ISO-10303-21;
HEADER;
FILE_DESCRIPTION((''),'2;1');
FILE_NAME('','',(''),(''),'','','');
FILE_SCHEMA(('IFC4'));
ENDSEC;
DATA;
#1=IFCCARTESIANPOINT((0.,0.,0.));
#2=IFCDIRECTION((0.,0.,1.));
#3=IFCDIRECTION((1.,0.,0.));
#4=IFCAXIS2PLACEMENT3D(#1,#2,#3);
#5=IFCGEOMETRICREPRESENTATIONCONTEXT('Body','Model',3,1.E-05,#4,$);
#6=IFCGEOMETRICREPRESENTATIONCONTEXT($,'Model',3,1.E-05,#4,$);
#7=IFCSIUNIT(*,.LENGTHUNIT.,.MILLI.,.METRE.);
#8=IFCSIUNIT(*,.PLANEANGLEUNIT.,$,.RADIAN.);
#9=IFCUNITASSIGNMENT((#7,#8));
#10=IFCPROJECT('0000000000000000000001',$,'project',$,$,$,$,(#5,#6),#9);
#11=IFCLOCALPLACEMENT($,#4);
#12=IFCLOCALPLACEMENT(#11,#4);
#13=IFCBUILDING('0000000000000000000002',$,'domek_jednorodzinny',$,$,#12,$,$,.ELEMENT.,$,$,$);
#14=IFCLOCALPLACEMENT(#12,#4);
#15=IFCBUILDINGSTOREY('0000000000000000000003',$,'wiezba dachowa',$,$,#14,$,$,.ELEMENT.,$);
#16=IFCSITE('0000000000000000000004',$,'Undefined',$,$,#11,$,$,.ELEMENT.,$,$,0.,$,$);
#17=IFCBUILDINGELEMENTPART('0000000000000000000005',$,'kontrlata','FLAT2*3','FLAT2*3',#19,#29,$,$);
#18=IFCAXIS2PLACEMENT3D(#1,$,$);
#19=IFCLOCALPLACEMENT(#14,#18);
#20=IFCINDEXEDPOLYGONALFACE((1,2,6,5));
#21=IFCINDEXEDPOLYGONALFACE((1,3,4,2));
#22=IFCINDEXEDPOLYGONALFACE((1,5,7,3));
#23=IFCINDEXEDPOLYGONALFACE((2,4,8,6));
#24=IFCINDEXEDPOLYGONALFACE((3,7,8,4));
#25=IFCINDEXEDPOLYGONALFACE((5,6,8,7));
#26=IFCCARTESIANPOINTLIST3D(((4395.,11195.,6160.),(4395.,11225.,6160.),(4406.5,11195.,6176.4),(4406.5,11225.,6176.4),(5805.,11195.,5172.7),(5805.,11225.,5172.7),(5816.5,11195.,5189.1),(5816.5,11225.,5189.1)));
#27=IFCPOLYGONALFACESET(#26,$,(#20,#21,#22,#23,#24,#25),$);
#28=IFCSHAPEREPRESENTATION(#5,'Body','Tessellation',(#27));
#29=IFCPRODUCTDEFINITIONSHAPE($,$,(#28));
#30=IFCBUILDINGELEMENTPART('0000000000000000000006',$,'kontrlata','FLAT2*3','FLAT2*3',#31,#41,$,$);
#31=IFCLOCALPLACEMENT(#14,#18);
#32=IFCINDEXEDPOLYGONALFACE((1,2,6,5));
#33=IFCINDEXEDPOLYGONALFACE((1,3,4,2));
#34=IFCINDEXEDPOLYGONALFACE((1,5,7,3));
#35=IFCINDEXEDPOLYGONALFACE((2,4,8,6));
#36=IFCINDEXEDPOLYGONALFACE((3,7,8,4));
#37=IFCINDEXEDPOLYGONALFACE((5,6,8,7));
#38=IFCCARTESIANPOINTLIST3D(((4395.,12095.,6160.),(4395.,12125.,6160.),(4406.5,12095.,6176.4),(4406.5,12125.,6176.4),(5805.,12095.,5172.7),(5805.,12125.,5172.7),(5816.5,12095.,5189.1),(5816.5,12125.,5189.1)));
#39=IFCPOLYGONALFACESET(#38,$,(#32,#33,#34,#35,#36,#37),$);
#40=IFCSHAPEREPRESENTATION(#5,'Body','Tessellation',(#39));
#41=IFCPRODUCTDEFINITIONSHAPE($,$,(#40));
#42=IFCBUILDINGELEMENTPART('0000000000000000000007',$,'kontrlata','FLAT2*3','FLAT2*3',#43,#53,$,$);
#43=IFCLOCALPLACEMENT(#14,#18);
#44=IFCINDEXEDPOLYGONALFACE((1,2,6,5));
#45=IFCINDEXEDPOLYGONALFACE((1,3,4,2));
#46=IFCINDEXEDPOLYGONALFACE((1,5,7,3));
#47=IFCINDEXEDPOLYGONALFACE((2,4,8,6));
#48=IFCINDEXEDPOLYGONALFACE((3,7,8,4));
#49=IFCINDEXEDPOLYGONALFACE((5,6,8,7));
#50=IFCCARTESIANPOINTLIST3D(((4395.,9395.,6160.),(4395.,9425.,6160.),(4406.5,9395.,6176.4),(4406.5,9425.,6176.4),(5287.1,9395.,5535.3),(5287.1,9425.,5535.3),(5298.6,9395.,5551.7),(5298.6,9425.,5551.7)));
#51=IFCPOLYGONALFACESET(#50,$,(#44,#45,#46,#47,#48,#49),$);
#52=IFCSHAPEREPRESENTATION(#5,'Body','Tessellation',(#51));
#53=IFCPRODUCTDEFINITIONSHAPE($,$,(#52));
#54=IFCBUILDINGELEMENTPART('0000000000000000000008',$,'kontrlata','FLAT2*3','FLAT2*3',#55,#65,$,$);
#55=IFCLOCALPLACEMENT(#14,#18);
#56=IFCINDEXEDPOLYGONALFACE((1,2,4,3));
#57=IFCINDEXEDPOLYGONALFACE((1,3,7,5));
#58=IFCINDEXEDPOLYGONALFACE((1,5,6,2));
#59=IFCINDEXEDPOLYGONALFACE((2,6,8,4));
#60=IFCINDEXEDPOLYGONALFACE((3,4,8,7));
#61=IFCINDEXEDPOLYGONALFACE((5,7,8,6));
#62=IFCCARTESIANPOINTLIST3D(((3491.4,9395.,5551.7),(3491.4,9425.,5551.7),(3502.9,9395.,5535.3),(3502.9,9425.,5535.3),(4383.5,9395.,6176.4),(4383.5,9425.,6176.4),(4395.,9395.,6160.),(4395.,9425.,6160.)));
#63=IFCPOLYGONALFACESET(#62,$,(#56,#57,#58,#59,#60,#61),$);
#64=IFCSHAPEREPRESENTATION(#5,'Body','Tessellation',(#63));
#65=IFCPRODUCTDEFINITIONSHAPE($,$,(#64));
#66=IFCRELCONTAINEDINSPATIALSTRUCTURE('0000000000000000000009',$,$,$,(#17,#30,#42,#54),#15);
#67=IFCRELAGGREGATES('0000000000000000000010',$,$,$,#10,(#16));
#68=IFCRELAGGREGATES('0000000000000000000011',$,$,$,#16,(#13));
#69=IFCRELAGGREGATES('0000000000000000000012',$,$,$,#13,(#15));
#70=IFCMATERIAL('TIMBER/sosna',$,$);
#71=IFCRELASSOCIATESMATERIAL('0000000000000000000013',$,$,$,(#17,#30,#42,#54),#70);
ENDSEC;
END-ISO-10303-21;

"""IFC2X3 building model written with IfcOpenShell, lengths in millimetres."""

from ifc_helpers import new_model, si_unit, frame, origin_with_axes, origin_2d_with_axis, place, context, project, spatial, rectangle, extrude, material, element, save


model = new_model("IFC2X3")

# Units and contexts
model_context_1 = context("Model", 3, precision=1e-05, world=origin_with_axes(), identifier="Body")
model_context_2 = context("Model", 3, precision=1e-05, world=origin_with_axes())
ifc_project = project(units=[si_unit("LENGTHUNIT", "METRE", prefix="MILLI"), si_unit("PLANEANGLEUNIT", "RADIAN")], contexts=[model_context_1, model_context_2])

# Site, building, storey
site_placement = place(None, origin_with_axes())
site = spatial("IfcSite", under=ifc_project, at=site_placement, Name="Undefined", CompositionType="ELEMENT", RefElevation=0.0)
building_placement = place(site_placement, origin_with_axes())
building = spatial("IfcBuilding", under=site, at=building_placement, Name="domek_jednorodzinny", CompositionType="ELEMENT")
storey_placement = place(building_placement, origin_with_axes())
storey = spatial("IfcBuildingStorey", under=building, at=storey_placement, Name="wiezba dachowa", CompositionType="ELEMENT")

# Building element parts
ifc_material = material(Name="TIMBER/sosna")
for number, where, z_axis, x_axis, name in (
    (1, (4400.7, 11210.0, 6168.2), (0.0, -1.0, 0.0), (0.819151, 0.0, -0.573578), "kontrlata"),
):
    element("IfcBuildingElementPart", number, at=place(storey_placement, frame(where, z_axis=z_axis, x_axis=x_axis)), inside=storey, material=ifc_material, Name=name, Description="FLAT2*3", ObjectType="FLAT2*3", context=model_context_1, shape_type="SweptSolid", body=[
        extrude(rectangle(XDim=20.0, YDim=30.0, at=origin_2d_with_axis()), frame((1721.3, 0.0, 0.0), z_axis=(-1.0, 0.0, 0.0), x_axis=(0.0, -1.0, 0.0)), (0.0, 0.0, 1.0), 1721.3),
    ])
building_element_part_1_placement = place(storey_placement, frame((4400.7, 12110.0, 6168.2), z_axis=(0.0, -1.0, 0.0), x_axis=(0.819151, 0.0, -0.573578)))
element("IfcBuildingElementPart", 2, at=building_element_part_1_placement, inside=storey, material=ifc_material, Name="kontrlata", Description="FLAT2*3", ObjectType="FLAT2*3", context=model_context_1, shape_type="SweptSolid", body=[
    extrude(rectangle(XDim=20.0, YDim=30.0, at=origin_2d_with_axis()), frame((1721.3, 0.0, 0.0), z_axis=(-1.0, 0.0, 0.0), x_axis=(0.0, -1.0, 0.0)), (0.0, 0.0, 1.0), 1721.3),
])
building_element_part_2_placement = place(storey_placement, frame((4400.7, 9410.0, 6168.2), z_axis=(0.0, -1.0, 0.0), x_axis=(0.819151, 0.0, -0.573578)))
element("IfcBuildingElementPart", 3, at=building_element_part_2_placement, inside=storey, material=ifc_material, Name="kontrlata", Description="FLAT2*3", ObjectType="FLAT2*3", context=model_context_1, shape_type="SweptSolid", body=[
    extrude(rectangle(XDim=20.0, YDim=30.0, at=origin_2d_with_axis()), frame((1089.1, 0.0, 0.0), z_axis=(-1.0, 0.0, 0.0), x_axis=(0.0, -1.0, 0.0)), (0.0, 0.0, 1.0), 1089.1),
])
building_element_part_3_placement = place(storey_placement, frame((3497.2, 9410.0, 5543.5), z_axis=(0.0, -1.0, 0.0), x_axis=(0.819152, 0.0, 0.573576)))
element("IfcBuildingElementPart", 4, at=building_element_part_3_placement, inside=storey, material=ifc_material, Name="kontrlata", Description="FLAT2*3", ObjectType="FLAT2*3", context=model_context_1, shape_type="SweptSolid", body=[
    extrude(rectangle(XDim=20.0, YDim=30.0, at=origin_2d_with_axis()), frame((1089.1, 0.0, 0.0), z_axis=(-1.0, 0.0, 0.0), x_axis=(0.0, -1.0, 0.0)), (0.0, 0.0, 1.0), 1089.1),
])

save(model, "model.ifc")
